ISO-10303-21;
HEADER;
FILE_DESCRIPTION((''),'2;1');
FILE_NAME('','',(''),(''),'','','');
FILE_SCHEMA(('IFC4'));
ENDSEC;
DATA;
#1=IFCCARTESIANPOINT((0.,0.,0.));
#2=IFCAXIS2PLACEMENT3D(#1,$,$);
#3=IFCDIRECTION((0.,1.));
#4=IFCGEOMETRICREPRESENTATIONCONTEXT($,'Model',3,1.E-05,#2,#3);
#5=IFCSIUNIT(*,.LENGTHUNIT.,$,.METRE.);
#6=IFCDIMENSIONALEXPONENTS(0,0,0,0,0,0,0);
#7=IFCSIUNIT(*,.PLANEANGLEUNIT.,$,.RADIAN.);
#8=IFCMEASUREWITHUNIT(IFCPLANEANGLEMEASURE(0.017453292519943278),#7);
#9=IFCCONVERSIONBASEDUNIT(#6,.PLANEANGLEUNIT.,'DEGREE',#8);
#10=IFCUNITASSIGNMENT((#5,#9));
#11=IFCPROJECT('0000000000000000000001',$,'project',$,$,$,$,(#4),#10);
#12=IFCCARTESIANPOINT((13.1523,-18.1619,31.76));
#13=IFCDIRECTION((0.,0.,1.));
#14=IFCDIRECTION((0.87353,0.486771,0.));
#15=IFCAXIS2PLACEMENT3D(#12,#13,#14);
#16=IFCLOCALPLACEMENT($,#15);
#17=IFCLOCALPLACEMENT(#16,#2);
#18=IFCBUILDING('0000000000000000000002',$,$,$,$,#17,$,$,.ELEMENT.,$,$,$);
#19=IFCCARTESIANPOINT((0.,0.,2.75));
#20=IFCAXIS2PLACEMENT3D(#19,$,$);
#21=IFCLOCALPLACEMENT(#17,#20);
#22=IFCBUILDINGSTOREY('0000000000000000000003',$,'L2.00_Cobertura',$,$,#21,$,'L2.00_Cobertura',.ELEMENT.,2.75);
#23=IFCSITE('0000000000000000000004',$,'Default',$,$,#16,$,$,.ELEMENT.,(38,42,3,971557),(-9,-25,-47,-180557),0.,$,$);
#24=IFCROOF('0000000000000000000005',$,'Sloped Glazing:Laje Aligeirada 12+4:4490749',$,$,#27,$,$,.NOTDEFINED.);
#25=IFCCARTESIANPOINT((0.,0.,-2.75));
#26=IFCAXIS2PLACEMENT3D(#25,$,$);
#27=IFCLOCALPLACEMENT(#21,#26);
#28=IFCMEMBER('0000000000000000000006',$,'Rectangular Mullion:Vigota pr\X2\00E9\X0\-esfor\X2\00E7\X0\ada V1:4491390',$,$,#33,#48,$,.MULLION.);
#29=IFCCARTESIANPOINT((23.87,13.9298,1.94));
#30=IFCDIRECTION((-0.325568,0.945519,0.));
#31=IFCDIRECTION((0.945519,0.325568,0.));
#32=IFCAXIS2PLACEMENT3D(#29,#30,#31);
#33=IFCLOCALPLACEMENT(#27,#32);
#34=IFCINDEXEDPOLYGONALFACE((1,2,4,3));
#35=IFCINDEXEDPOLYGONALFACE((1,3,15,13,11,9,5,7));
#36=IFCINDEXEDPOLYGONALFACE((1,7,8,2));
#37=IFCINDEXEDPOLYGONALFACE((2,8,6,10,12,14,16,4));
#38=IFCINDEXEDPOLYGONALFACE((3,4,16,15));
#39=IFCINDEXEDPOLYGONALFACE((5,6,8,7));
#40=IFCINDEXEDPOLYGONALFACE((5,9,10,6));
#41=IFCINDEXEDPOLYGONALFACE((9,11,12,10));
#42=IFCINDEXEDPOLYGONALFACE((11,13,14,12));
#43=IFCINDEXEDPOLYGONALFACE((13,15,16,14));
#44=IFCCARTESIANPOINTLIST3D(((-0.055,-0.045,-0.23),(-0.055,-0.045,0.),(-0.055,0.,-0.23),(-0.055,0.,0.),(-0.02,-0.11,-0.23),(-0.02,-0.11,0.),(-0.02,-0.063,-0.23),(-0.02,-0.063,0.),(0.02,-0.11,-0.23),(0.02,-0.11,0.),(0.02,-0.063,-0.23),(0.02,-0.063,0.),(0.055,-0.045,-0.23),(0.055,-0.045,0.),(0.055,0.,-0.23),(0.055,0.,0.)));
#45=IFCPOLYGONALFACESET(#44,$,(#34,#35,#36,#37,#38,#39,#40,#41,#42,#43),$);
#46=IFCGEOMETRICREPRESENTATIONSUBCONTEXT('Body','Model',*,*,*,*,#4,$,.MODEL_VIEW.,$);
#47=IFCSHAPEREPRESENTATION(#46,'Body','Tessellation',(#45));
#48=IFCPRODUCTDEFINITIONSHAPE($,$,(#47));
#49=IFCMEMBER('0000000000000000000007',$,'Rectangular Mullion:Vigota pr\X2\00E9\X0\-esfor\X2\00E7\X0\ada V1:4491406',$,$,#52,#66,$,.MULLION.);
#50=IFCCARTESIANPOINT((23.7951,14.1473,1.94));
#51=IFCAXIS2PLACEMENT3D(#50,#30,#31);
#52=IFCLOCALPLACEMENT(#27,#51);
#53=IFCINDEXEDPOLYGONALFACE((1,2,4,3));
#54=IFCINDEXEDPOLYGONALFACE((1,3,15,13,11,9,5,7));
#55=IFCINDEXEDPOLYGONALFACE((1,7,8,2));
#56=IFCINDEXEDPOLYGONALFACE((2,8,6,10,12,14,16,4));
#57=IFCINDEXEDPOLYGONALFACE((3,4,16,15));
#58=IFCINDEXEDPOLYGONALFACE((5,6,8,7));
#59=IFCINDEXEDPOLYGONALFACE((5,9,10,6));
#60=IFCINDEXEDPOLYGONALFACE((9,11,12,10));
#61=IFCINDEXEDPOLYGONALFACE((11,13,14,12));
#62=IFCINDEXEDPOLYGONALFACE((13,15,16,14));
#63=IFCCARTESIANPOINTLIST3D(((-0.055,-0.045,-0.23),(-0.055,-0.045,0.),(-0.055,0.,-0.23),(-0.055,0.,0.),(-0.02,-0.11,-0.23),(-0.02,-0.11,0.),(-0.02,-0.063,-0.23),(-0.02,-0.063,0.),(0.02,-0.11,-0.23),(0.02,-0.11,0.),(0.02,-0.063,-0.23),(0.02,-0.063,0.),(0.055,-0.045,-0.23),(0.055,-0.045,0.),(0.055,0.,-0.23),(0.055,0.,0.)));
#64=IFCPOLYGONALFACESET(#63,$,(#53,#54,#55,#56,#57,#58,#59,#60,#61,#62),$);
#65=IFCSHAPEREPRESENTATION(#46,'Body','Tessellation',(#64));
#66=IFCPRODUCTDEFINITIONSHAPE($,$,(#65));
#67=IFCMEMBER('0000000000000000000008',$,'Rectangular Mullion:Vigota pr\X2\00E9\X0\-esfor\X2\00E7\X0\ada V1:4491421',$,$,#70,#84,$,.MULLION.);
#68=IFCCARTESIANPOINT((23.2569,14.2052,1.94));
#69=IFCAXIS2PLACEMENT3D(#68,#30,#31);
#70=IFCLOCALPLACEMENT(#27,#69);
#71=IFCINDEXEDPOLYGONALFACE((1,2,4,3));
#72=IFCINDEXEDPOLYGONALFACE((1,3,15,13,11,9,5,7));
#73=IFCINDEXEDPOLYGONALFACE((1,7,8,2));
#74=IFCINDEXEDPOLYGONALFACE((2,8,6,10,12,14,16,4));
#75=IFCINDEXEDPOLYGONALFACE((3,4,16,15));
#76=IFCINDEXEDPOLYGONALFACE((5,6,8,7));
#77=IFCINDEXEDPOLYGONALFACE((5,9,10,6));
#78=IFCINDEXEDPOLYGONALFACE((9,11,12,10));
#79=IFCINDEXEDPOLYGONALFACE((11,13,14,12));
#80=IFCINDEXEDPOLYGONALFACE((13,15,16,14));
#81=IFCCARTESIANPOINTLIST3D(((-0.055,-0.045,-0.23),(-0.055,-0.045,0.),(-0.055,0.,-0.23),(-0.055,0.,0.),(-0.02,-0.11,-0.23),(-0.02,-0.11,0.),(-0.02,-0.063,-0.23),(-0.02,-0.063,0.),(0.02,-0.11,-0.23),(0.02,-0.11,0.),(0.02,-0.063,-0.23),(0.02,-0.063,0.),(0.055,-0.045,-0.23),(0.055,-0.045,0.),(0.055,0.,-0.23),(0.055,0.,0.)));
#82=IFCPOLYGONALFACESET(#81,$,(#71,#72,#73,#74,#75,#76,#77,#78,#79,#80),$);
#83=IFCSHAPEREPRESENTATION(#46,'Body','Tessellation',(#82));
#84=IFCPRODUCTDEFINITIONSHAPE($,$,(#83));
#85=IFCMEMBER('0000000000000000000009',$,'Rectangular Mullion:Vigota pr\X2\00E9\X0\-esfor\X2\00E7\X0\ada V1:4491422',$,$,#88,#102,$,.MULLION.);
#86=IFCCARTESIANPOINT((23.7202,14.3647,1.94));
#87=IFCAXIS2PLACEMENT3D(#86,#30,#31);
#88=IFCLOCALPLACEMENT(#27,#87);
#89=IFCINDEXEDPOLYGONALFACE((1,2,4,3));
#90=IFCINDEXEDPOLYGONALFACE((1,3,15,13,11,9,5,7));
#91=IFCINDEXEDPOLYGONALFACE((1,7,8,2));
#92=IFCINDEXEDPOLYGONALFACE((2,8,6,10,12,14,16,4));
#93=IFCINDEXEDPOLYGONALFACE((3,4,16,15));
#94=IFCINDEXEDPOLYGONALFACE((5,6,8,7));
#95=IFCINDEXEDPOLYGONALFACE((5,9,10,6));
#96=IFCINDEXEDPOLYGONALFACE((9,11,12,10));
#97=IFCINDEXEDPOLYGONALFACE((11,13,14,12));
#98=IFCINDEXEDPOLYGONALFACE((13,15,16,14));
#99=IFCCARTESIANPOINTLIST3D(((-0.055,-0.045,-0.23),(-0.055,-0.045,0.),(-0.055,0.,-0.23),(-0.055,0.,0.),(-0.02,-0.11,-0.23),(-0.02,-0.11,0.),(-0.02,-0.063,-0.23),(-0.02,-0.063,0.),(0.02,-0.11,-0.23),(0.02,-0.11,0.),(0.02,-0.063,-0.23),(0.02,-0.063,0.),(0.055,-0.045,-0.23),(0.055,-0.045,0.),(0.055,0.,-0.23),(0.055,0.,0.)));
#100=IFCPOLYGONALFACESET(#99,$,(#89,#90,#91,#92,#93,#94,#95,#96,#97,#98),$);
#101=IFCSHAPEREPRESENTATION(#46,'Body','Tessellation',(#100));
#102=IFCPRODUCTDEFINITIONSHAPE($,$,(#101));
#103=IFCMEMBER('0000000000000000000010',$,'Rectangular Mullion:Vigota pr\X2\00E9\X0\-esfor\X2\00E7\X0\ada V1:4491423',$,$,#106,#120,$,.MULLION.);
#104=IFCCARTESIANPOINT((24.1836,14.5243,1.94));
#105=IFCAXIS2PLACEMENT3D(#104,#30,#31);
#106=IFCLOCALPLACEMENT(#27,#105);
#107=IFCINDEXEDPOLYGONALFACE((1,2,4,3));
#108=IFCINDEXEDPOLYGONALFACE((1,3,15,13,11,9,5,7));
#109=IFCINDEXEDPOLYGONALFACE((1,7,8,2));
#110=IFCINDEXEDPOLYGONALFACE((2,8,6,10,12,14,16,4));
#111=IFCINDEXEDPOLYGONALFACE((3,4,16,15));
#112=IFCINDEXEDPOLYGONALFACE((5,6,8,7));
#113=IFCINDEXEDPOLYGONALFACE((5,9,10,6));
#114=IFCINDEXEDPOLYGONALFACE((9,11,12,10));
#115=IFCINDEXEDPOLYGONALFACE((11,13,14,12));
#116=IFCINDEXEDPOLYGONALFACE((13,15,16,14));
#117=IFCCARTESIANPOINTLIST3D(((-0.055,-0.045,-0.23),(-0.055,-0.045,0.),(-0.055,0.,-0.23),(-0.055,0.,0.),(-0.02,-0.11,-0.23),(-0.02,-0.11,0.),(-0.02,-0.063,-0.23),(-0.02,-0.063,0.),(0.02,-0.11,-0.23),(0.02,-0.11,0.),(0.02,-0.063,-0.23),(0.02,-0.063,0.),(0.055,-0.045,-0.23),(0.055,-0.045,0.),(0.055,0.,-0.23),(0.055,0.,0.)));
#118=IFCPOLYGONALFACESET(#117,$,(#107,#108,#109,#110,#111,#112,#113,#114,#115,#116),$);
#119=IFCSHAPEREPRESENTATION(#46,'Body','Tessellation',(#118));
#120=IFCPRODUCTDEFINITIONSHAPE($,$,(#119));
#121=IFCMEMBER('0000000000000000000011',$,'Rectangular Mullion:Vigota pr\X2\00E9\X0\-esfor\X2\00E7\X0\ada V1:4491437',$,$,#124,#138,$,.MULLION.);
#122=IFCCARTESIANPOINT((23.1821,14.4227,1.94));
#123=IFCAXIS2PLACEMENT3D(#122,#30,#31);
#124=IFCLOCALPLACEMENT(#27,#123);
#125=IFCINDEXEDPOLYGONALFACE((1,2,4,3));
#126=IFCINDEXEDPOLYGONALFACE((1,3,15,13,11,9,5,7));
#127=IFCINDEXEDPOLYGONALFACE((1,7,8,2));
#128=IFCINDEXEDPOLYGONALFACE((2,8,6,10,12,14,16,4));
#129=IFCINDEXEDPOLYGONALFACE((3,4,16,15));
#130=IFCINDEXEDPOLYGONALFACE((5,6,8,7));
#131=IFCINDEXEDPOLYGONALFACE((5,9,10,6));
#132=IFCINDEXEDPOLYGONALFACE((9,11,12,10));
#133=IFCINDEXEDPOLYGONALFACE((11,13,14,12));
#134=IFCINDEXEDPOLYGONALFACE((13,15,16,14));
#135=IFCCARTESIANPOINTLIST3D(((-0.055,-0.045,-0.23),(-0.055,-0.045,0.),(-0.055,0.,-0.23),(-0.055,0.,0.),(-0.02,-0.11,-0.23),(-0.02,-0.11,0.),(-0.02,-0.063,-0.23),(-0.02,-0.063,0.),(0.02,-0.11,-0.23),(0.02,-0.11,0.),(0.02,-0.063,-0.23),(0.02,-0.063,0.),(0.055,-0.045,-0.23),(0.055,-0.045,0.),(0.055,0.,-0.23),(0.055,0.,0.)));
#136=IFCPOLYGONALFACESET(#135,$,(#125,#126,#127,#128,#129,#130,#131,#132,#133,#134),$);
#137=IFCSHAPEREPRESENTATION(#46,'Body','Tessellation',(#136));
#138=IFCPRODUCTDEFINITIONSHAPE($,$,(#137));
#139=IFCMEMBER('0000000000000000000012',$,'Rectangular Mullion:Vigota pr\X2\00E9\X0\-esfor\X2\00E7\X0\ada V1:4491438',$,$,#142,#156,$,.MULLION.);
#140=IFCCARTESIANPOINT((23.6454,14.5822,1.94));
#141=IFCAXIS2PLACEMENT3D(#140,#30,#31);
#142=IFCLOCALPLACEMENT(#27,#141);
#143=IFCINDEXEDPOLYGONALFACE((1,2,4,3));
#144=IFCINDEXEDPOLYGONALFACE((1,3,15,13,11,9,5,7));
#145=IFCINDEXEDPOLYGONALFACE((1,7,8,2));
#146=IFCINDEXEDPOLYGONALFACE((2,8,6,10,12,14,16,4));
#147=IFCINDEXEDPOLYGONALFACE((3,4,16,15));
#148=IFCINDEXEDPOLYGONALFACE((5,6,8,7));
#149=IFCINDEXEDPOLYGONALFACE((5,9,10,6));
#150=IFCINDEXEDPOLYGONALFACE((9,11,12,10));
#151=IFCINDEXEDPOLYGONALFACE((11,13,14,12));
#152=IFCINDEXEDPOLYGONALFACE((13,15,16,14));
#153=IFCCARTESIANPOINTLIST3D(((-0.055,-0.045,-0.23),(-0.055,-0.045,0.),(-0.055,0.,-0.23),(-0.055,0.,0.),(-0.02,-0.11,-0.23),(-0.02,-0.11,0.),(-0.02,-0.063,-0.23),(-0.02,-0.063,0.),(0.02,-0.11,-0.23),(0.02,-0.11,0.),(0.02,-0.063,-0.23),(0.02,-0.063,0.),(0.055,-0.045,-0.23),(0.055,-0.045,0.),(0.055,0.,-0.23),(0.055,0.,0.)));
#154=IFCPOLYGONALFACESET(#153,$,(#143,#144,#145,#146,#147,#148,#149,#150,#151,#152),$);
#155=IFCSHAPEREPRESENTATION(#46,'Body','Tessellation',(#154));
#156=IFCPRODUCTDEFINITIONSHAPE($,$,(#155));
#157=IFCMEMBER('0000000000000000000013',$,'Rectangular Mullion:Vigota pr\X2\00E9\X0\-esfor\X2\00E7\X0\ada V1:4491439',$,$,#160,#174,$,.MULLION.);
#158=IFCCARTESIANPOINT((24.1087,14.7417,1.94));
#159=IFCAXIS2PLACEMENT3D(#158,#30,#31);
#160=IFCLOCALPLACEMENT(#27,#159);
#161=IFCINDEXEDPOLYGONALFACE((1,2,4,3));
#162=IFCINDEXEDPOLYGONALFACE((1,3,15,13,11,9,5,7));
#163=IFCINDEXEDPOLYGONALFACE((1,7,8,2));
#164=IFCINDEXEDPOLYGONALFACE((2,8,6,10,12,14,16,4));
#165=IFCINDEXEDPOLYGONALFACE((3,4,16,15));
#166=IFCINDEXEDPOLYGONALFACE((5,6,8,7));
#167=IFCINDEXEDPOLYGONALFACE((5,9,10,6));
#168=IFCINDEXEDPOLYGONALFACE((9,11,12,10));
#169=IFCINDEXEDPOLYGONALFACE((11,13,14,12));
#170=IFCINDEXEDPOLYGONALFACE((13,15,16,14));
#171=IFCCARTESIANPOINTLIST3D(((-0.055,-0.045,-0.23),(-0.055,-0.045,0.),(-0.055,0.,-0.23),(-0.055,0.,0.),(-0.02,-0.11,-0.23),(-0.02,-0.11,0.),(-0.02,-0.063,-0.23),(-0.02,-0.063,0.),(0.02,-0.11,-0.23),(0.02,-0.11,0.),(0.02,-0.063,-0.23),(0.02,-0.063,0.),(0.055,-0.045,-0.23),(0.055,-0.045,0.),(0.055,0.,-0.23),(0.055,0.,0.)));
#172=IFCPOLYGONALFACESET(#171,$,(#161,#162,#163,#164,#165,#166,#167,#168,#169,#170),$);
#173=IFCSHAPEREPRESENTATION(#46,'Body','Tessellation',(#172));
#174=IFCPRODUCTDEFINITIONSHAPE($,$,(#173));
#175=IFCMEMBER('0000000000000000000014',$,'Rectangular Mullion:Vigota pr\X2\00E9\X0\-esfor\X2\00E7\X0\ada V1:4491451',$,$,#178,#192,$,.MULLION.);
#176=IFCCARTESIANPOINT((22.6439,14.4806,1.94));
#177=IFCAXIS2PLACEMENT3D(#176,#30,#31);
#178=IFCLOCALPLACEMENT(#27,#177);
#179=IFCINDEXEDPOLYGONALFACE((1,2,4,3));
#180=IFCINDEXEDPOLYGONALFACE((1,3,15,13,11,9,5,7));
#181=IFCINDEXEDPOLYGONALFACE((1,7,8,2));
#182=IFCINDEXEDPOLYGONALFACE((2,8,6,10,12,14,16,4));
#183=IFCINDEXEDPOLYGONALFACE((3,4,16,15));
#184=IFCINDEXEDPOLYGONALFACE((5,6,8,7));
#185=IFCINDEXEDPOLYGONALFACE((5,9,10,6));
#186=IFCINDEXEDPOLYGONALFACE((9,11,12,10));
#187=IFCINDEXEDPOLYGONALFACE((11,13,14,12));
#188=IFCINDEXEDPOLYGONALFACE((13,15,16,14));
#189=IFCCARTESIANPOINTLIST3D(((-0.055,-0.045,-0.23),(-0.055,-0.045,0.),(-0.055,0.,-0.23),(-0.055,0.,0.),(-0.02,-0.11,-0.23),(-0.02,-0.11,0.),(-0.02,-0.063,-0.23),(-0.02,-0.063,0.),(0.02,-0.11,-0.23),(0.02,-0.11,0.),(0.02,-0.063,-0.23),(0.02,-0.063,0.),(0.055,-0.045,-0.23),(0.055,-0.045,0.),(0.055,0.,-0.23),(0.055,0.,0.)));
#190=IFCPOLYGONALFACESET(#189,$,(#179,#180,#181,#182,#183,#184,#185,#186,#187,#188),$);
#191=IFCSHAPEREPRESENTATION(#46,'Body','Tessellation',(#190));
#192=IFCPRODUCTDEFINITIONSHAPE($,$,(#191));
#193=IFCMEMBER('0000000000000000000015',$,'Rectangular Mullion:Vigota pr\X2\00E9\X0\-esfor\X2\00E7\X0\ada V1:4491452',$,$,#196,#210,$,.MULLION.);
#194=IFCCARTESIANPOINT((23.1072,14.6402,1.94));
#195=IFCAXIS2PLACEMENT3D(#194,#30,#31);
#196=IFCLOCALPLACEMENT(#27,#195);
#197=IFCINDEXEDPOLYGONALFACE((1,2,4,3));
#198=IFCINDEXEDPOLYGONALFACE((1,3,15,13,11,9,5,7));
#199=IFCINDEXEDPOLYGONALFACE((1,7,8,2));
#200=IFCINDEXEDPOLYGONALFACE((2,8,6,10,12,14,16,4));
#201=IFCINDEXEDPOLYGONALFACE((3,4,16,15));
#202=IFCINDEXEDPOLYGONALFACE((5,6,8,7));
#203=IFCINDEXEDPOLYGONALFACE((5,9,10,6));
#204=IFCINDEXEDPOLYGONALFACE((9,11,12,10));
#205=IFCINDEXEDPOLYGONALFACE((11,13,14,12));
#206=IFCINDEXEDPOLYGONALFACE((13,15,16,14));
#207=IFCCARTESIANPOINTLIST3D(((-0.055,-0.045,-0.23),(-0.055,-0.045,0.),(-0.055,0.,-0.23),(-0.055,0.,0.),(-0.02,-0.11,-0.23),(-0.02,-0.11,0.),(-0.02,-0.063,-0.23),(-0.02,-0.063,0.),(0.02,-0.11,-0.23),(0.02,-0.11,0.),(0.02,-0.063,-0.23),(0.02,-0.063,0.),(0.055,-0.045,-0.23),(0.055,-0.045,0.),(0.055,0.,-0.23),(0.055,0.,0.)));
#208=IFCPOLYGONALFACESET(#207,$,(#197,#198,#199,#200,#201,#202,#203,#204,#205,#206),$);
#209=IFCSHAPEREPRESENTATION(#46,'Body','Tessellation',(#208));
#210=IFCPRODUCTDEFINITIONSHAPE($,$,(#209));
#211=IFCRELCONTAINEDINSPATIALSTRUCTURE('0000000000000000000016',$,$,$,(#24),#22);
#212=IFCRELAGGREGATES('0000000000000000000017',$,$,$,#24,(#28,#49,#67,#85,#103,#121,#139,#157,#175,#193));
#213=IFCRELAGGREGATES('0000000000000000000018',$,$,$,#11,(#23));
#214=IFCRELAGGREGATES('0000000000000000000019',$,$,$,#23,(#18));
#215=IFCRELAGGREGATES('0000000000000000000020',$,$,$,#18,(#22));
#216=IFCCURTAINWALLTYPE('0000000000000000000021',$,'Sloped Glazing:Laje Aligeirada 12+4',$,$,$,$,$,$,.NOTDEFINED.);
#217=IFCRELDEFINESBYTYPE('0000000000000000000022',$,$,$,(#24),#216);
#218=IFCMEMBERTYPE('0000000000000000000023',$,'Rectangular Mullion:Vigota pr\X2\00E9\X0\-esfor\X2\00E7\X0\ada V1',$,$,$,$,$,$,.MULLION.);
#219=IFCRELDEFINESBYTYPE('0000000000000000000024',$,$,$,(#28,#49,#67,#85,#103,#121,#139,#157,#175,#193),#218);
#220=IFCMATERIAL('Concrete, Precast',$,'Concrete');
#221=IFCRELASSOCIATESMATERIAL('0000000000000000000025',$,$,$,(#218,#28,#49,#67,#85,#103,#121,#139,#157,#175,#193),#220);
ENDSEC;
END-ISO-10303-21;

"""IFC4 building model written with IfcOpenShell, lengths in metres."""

from ifc_helpers import new_model, entity, si_unit, converted_unit, direction, frame, origin, place, context, subcontext, project, spatial, indexed_curve, outline, extrude, source, transform, mapped, material, type_object, type_shapes, element, aggregate, save


model = new_model("IFC4")

# Units and contexts
model_context = context("Model", 3, precision=1e-05, world=origin(), true_north=direction((0.0, 1.0)))
body_context = subcontext(model_context, "Body", "Model", "MODEL_VIEW")
ifc_project = project(units=[si_unit("LENGTHUNIT", "METRE"), converted_unit("PLANEANGLEUNIT", "DEGREE", entity("IfcPlaneAngleMeasure", 0.017453292519943278), si_unit("PLANEANGLEUNIT", "RADIAN"), dimensions=[0, 0, 0, 0, 0, 0, 0])], contexts=[model_context])

# Site, building, storey
site_placement = place(None, frame((13.1523, -18.1619, 31.76), z_axis=(0.0, 0.0, 1.0), x_axis=(0.87353, 0.486771, 0.0)))
site = spatial("IfcSite", under=ifc_project, at=site_placement, Name="Default", CompositionType="ELEMENT", RefLatitude=(38, 42, 3, 971557), RefLongitude=(-9, -25, -47, -180557), RefElevation=0.0)
building_placement = place(site_placement, origin())
building = spatial("IfcBuilding", under=site, at=building_placement, CompositionType="ELEMENT")
storey_placement = place(building_placement, frame((0.0, 0.0, 2.75)))
storey = spatial("IfcBuildingStorey", under=building, at=storey_placement, Name="L2.00_Cobertura", LongName="L2.00_Cobertura", CompositionType="ELEMENT", Elevation=2.75)

# Roof, members
curtain_wall_type = type_object("IfcCurtainWallType", Name="Sloped Glazing:Laje Aligeirada 12+4", PredefinedType="NOTDEFINED")
roof_placement = place(storey_placement, frame((0.0, 0.0, -2.75)))
roof = element("IfcRoof", 1, at=roof_placement, inside=storey, type_object=curtain_wall_type, Name="Sloped Glazing:Laje Aligeirada 12+4:4490749", PredefinedType="NOTDEFINED")
ifc_material_1 = material(Name="Concrete, Precast", Category="Concrete")
member_type_1 = type_object("IfcMemberType", Name="Rectangular Mullion:Vigota pré-esforçada V1", PredefinedType="MULLION", material=ifc_material_1)
shared_shape_1 = source(origin(), body_context, "Body", "SweptSolid", [
    extrude(outline(indexed_curve([(-0.055, -0.0545), (0.055, -0.0545), (0.055, -0.0095), (0.02, 0.0085), (0.02, 0.0555), (-0.02, 0.0555), (-0.02, 0.0085), (-0.055, -0.0095), (-0.055, -0.0545)], self_intersect=False)), frame((0.0, -0.0545, -0.23), z_axis=(0.0, 0.0, 1.0), x_axis=(-1.0, 0.0, 0.0)), (0.0, 0.0, 1.0), 0.23),
])
type_shapes(member_type_1, [shared_shape_1])
member_1_placement = place(roof_placement, frame((23.87, 13.9298, 1.94), z_axis=(-0.325568, 0.945519, 0.0), x_axis=(0.945519, 0.325568, 0.0)))
member_1 = element("IfcMember", 2, at=member_1_placement, type_object=member_type_1, material=ifc_material_1, Name="Rectangular Mullion:Vigota pré-esforçada V1:4491390", PredefinedType="MULLION", context=body_context, shape_type="MappedRepresentation", body=[
    mapped(shared_shape_1, transform((0.0, 0.0, 0.0), scale=1.0)),
])
member_2_placement = place(roof_placement, frame((23.7951, 14.1473, 1.94), z_axis=(-0.325568, 0.945519, 0.0), x_axis=(0.945519, 0.325568, 0.0)))
member_2 = element("IfcMember", 3, at=member_2_placement, type_object=member_type_1, material=ifc_material_1, Name="Rectangular Mullion:Vigota pré-esforçada V1:4491406", PredefinedType="MULLION", context=body_context, shape_type="MappedRepresentation", body=[
    mapped(shared_shape_1, transform((0.0, 0.0, 0.0), scale=1.0)),
])
member_3_placement = place(roof_placement, frame((23.2569, 14.2052, 1.94), z_axis=(-0.325568, 0.945519, 0.0), x_axis=(0.945519, 0.325568, 0.0)))
member_3 = element("IfcMember", 4, at=member_3_placement, type_object=member_type_1, material=ifc_material_1, Name="Rectangular Mullion:Vigota pré-esforçada V1:4491421", PredefinedType="MULLION", context=body_context, shape_type="MappedRepresentation", body=[
    mapped(shared_shape_1, transform((0.0, 0.0, 0.0), scale=1.0)),
])
member_4_placement = place(roof_placement, frame((23.7202, 14.3647, 1.94), z_axis=(-0.325568, 0.945519, 0.0), x_axis=(0.945519, 0.325568, 0.0)))
member_4 = element("IfcMember", 5, at=member_4_placement, type_object=member_type_1, material=ifc_material_1, Name="Rectangular Mullion:Vigota pré-esforçada V1:4491422", PredefinedType="MULLION", context=body_context, shape_type="MappedRepresentation", body=[
    mapped(shared_shape_1, transform((0.0, 0.0, 0.0), scale=1.0)),
])
member_5_placement = place(roof_placement, frame((24.1836, 14.5243, 1.94), z_axis=(-0.325568, 0.945519, 0.0), x_axis=(0.945519, 0.325568, 0.0)))
member_5 = element("IfcMember", 6, at=member_5_placement, type_object=member_type_1, material=ifc_material_1, Name="Rectangular Mullion:Vigota pré-esforçada V1:4491423", PredefinedType="MULLION", context=body_context, shape_type="MappedRepresentation", body=[
    mapped(shared_shape_1, transform((0.0, 0.0, 0.0), scale=1.0)),
])
member_6_placement = place(roof_placement, frame((23.1821, 14.4227, 1.94), z_axis=(-0.325568, 0.945519, 0.0), x_axis=(0.945519, 0.325568, 0.0)))
member_6 = element("IfcMember", 7, at=member_6_placement, type_object=member_type_1, material=ifc_material_1, Name="Rectangular Mullion:Vigota pré-esforçada V1:4491437", PredefinedType="MULLION", context=body_context, shape_type="MappedRepresentation", body=[
    mapped(shared_shape_1, transform((0.0, 0.0, 0.0), scale=1.0)),
])
member_7_placement = place(roof_placement, frame((23.6454, 14.5822, 1.94), z_axis=(-0.325568, 0.945519, 0.0), x_axis=(0.945519, 0.325568, 0.0)))
member_7 = element("IfcMember", 8, at=member_7_placement, type_object=member_type_1, material=ifc_material_1, Name="Rectangular Mullion:Vigota pré-esforçada V1:4491438", PredefinedType="MULLION", context=body_context, shape_type="MappedRepresentation", body=[
    mapped(shared_shape_1, transform((0.0, 0.0, 0.0), scale=1.0)),
])
member_8_placement = place(roof_placement, frame((24.1087, 14.7417, 1.94), z_axis=(-0.325568, 0.945519, 0.0), x_axis=(0.945519, 0.325568, 0.0)))
member_8 = element("IfcMember", 9, at=member_8_placement, type_object=member_type_1, material=ifc_material_1, Name="Rectangular Mullion:Vigota pré-esforçada V1:4491439", PredefinedType="MULLION", context=body_context, shape_type="MappedRepresentation", body=[
    mapped(shared_shape_1, transform((0.0, 0.0, 0.0), scale=1.0)),
])
member_9_placement = place(roof_placement, frame((22.6439, 14.4806, 1.94), z_axis=(-0.325568, 0.945519, 0.0), x_axis=(0.945519, 0.325568, 0.0)))
member_9 = element("IfcMember", 10, at=member_9_placement, type_object=member_type_1, material=ifc_material_1, Name="Rectangular Mullion:Vigota pré-esforçada V1:4491451", PredefinedType="MULLION", context=body_context, shape_type="MappedRepresentation", body=[
    mapped(shared_shape_1, transform((0.0, 0.0, 0.0), scale=1.0)),
])
member_10_placement = place(roof_placement, frame((23.1072, 14.6402, 1.94), z_axis=(-0.325568, 0.945519, 0.0), x_axis=(0.945519, 0.325568, 0.0)))
member_10 = element("IfcMember", 11, at=member_10_placement, type_object=member_type_1, material=ifc_material_1, Name="Rectangular Mullion:Vigota pré-esforçada V1:4491452", PredefinedType="MULLION", context=body_context, shape_type="MappedRepresentation", body=[
    mapped(shared_shape_1, transform((0.0, 0.0, 0.0), scale=1.0)),
])
aggregate(roof, [member_1, member_2, member_3, member_4, member_5, member_6, member_7, member_8, member_9, member_10])

save(model, "model.ifc")
